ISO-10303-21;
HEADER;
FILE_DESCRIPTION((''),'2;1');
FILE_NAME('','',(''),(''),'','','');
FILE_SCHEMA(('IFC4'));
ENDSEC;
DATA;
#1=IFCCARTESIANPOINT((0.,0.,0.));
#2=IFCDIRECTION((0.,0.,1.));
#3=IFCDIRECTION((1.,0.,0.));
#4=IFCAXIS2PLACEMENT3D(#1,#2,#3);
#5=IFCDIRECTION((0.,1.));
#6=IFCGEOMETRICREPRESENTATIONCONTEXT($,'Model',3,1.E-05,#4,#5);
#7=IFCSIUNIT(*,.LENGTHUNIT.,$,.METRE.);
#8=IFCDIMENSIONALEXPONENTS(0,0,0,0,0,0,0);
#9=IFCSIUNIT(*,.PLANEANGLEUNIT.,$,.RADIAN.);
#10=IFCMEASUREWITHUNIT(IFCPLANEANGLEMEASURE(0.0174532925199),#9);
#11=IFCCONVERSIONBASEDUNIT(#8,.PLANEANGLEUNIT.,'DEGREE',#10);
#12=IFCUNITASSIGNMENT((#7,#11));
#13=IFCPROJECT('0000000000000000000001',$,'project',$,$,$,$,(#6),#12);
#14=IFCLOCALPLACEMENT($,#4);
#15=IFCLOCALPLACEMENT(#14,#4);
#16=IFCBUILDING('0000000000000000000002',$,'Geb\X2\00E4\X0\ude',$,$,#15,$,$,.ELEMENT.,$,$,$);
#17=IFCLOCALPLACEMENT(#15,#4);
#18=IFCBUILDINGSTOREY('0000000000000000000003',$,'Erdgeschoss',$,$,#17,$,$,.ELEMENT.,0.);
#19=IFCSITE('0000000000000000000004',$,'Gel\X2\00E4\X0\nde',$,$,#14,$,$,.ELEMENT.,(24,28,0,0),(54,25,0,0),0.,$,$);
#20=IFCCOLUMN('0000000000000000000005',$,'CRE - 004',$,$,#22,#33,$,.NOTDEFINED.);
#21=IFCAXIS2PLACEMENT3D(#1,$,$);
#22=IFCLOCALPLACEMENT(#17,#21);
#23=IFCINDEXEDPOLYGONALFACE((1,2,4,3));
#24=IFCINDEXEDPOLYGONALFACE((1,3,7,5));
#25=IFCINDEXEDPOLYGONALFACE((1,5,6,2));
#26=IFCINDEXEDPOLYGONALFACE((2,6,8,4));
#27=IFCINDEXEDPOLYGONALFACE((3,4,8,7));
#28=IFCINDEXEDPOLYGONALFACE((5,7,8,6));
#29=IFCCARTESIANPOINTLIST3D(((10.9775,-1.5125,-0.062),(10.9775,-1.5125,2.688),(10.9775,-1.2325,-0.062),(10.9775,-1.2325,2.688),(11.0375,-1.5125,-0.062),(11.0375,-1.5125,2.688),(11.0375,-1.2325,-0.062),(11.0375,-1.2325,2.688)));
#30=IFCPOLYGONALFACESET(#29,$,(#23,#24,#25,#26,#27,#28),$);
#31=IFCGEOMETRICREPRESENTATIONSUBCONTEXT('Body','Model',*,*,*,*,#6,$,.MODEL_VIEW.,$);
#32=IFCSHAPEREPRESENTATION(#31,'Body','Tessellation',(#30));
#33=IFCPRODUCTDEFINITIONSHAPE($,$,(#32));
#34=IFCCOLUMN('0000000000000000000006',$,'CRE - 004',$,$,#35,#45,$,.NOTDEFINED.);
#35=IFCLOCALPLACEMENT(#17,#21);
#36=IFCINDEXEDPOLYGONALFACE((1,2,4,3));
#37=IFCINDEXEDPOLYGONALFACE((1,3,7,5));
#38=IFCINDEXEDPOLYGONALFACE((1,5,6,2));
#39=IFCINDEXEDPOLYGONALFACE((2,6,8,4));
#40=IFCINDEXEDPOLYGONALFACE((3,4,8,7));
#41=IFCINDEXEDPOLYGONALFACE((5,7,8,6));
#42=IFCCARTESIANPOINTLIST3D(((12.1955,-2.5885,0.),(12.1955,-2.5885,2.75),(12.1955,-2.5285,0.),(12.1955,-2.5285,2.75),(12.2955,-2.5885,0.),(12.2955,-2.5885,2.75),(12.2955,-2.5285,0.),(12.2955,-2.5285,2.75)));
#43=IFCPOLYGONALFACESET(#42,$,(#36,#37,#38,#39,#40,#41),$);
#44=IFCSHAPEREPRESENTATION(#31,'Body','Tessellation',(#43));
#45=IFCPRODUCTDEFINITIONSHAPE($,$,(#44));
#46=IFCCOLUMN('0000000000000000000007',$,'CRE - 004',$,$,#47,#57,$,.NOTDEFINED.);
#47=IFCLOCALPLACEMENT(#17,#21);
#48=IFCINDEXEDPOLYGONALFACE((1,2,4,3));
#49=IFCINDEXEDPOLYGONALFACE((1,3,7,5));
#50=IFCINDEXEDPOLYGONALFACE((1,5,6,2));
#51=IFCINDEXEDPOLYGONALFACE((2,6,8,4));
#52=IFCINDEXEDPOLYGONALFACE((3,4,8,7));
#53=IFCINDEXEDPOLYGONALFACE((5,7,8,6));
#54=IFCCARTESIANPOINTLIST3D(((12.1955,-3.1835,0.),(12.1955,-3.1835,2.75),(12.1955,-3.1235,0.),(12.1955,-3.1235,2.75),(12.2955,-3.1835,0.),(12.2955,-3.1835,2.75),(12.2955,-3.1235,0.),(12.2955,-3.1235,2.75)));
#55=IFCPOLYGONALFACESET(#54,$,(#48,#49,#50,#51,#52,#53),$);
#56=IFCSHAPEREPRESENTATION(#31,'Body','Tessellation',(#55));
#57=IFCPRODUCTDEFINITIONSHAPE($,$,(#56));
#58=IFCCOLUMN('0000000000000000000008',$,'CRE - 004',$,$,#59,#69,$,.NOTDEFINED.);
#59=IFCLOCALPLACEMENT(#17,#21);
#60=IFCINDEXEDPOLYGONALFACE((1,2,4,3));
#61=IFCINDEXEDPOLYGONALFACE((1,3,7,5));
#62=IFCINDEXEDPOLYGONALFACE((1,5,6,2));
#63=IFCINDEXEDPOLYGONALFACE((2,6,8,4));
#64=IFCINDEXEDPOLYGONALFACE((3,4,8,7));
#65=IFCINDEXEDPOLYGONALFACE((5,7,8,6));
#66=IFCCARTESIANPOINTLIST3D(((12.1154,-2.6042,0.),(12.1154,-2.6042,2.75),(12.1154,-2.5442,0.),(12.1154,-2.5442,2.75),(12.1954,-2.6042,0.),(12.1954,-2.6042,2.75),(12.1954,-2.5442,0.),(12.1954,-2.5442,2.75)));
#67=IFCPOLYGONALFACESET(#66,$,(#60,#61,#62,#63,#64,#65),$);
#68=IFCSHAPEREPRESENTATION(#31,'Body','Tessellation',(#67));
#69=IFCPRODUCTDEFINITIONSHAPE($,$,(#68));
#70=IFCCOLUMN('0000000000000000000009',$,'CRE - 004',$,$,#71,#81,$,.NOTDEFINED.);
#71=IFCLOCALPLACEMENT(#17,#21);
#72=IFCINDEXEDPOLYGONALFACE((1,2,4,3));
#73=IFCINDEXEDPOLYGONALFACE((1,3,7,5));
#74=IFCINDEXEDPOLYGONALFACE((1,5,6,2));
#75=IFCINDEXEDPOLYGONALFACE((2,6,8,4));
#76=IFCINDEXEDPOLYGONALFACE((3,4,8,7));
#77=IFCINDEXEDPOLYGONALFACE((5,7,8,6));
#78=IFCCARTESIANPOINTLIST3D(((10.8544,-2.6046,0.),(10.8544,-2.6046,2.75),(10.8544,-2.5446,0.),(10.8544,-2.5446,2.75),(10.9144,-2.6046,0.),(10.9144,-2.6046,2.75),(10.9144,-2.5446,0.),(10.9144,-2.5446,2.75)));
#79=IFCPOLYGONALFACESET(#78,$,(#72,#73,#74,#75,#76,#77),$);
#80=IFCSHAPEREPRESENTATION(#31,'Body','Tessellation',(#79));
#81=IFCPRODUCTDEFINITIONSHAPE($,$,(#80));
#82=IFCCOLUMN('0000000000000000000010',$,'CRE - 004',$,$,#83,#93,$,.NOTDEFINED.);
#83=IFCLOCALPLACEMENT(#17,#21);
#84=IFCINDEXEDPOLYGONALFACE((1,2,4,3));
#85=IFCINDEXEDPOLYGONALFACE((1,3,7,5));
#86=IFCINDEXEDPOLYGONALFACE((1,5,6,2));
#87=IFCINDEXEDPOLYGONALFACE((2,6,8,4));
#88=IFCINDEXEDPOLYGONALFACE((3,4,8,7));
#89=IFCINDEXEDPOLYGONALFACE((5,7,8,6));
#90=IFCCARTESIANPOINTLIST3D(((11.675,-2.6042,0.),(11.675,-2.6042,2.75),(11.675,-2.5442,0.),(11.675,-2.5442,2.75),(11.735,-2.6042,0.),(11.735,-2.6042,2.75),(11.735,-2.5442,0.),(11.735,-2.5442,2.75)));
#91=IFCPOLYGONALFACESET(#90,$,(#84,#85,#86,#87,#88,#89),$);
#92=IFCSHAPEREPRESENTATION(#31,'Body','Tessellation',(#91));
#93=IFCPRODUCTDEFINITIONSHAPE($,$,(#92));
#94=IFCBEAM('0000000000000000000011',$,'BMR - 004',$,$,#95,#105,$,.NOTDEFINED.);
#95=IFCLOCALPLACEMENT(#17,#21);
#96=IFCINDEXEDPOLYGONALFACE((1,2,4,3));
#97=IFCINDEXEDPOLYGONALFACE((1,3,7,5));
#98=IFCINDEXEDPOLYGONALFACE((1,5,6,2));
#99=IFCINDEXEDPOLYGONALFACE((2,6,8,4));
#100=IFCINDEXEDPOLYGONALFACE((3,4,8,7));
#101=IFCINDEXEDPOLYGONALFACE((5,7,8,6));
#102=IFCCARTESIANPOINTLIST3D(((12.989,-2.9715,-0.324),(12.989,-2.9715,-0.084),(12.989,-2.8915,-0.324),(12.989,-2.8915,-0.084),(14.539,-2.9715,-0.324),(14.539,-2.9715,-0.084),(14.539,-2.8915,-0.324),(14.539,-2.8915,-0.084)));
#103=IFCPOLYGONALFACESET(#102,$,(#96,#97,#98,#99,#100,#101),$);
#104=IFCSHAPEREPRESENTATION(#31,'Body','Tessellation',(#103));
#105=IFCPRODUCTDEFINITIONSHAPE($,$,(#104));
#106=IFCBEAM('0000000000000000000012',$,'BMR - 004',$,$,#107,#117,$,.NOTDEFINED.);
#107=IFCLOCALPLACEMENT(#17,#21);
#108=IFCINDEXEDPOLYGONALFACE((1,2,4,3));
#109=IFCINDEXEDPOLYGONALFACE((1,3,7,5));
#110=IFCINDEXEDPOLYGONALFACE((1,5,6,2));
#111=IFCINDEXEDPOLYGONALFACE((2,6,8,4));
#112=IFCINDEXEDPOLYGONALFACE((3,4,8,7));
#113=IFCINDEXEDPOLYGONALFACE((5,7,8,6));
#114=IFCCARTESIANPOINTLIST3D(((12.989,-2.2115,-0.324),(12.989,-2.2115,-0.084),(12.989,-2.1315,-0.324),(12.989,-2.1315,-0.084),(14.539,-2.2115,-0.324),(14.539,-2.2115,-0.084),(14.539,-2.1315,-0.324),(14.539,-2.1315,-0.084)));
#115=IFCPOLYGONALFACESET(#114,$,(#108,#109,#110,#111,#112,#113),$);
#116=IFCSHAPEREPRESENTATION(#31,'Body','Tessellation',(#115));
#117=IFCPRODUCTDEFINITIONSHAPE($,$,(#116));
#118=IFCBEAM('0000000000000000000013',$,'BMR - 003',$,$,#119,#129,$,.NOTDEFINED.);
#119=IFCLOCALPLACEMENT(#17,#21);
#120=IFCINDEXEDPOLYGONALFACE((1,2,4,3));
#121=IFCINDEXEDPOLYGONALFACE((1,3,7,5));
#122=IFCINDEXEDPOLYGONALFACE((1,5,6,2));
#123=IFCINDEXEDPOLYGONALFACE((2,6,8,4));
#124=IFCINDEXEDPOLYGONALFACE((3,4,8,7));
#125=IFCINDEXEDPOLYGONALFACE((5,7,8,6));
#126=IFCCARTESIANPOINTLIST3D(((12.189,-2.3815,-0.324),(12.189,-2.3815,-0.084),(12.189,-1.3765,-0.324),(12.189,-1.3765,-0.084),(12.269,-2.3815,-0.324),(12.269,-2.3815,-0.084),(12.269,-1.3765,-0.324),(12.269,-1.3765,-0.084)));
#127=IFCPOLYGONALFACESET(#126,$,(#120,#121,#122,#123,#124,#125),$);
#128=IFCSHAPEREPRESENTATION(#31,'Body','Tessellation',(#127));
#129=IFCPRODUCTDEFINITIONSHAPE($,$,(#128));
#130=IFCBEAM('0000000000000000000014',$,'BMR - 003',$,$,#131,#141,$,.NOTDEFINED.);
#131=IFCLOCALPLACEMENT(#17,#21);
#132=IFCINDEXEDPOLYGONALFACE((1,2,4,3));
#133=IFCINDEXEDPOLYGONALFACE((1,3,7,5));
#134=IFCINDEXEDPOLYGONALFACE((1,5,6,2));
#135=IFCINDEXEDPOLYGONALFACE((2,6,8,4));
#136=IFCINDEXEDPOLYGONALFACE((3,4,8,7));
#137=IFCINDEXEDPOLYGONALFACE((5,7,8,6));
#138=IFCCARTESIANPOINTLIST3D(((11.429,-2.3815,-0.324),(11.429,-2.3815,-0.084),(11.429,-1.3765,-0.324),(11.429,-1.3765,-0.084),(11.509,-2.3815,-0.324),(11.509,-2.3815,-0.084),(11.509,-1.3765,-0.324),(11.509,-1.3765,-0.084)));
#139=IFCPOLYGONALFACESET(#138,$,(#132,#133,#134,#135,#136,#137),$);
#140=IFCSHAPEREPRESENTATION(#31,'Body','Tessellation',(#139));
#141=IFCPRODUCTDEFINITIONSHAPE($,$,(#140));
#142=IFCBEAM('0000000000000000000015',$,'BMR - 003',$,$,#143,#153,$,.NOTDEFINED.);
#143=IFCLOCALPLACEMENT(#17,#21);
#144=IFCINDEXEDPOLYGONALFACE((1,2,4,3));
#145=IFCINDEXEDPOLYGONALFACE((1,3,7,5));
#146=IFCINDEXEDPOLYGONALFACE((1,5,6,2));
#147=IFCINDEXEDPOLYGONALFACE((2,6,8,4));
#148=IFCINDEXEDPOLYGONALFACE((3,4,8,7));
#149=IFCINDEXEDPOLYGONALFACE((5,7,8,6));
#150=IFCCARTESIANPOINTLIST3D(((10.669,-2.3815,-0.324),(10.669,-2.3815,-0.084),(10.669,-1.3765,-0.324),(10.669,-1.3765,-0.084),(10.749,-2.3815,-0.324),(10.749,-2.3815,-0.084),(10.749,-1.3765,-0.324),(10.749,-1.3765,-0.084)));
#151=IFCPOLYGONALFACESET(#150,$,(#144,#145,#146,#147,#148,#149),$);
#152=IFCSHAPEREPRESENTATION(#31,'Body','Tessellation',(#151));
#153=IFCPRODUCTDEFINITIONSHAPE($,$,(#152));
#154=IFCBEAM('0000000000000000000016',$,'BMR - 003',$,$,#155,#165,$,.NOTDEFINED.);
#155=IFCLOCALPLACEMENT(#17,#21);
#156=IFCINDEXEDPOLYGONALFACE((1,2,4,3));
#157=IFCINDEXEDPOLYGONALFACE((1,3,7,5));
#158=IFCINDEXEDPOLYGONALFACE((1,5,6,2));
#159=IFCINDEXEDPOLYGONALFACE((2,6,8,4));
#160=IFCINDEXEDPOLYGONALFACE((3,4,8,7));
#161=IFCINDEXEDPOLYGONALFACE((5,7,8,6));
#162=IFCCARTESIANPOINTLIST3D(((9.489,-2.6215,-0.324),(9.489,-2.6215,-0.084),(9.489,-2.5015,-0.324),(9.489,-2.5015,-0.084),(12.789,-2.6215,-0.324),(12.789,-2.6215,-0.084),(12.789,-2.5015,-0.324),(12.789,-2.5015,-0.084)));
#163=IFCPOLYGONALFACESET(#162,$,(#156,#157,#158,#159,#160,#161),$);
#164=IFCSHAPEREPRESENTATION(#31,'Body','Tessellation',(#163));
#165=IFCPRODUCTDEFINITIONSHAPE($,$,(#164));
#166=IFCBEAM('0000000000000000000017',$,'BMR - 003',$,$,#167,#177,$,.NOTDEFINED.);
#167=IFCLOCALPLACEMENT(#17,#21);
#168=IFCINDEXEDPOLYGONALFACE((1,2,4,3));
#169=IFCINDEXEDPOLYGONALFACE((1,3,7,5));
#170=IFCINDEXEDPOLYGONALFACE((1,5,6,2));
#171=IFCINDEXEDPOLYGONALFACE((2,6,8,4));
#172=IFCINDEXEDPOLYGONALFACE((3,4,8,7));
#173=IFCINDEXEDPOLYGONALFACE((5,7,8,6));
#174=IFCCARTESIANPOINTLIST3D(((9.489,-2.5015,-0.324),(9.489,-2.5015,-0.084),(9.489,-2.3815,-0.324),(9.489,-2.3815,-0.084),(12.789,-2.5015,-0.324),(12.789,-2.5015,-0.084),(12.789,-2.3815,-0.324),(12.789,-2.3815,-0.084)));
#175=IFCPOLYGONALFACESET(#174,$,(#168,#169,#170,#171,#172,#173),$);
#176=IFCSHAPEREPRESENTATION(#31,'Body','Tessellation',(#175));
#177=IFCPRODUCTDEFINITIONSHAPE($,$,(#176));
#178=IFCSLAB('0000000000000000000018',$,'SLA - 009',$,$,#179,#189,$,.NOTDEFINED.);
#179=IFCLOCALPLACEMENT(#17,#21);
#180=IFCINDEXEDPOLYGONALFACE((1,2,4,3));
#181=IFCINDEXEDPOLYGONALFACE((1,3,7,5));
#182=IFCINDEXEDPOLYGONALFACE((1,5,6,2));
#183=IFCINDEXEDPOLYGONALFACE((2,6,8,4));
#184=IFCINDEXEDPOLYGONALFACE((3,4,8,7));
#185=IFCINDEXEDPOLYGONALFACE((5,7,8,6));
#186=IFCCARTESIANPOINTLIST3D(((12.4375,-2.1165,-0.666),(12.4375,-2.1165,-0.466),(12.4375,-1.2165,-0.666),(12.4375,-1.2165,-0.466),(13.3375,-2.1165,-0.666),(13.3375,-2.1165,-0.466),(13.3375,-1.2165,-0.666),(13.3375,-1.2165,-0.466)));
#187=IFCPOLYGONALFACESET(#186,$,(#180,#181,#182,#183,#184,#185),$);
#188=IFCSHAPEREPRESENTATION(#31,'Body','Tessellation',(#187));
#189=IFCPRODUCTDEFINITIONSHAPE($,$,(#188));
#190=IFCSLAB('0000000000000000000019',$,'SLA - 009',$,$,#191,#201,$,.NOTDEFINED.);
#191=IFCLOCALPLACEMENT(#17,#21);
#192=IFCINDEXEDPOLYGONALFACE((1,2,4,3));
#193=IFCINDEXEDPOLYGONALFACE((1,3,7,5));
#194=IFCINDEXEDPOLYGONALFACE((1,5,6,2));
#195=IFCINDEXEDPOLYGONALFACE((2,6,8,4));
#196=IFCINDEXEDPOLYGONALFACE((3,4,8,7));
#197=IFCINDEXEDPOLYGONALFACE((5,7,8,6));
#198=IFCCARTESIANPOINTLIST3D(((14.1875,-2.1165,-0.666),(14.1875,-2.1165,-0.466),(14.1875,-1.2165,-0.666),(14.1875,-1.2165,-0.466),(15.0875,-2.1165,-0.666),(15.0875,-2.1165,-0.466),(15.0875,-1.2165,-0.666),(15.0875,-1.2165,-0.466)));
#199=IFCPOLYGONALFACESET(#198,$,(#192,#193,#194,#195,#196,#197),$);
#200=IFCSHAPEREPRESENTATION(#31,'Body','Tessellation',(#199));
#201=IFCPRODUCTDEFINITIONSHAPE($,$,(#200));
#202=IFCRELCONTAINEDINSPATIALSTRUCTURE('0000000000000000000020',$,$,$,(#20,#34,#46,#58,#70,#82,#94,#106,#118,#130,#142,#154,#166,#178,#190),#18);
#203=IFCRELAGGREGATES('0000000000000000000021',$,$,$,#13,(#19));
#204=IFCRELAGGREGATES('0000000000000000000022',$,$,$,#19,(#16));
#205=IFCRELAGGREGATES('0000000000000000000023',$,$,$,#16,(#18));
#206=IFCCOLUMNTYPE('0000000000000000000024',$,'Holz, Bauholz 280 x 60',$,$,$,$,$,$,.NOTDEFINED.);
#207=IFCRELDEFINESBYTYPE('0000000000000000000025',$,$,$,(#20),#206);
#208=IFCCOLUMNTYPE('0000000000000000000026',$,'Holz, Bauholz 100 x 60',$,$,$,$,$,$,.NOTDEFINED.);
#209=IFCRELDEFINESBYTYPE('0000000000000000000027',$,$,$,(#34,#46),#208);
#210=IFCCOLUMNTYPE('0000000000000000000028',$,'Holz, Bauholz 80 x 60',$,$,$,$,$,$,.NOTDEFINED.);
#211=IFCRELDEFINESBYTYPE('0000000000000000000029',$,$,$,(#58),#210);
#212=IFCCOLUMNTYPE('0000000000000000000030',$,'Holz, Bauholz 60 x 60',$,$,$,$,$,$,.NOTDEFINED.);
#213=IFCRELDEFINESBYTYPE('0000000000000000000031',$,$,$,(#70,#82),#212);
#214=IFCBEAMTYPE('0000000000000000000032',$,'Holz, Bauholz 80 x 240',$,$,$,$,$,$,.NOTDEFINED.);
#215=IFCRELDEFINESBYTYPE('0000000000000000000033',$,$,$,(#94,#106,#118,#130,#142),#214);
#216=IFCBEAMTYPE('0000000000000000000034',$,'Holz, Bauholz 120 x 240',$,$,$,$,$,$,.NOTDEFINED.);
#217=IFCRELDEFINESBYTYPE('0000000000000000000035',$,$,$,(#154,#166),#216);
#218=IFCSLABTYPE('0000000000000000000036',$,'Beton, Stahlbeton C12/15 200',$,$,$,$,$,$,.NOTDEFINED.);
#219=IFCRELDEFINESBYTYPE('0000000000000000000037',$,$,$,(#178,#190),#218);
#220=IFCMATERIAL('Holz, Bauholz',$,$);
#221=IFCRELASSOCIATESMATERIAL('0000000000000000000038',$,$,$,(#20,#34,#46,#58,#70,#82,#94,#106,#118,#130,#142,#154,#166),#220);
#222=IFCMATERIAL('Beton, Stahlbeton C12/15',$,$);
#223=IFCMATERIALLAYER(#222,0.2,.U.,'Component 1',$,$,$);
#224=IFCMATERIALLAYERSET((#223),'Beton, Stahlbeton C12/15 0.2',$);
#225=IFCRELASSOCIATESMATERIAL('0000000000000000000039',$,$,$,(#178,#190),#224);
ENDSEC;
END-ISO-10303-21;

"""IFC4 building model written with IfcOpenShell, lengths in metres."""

from ifc_helpers import new_model, entity, si_unit, converted_unit, direction, frame, frame_2d, origin_with_axes, origin_2d_with_axis, place, context, subcontext, project, spatial, line, indexed_curve, rectangle, outline, extrude, material, layer, layer_set, layer_usage, type_object, element, save


model = new_model("IFC4")

# Units and contexts
model_context = context("Model", 3, precision=1e-05, world=origin_with_axes(), true_north=direction((0.0, 1.0)))
body_context = subcontext(model_context, "Body", "Model", "MODEL_VIEW")
ifc_project = project(units=[si_unit("LENGTHUNIT", "METRE"), converted_unit("PLANEANGLEUNIT", "DEGREE", entity("IfcPlaneAngleMeasure", 0.0174532925199), si_unit("PLANEANGLEUNIT", "RADIAN"), dimensions=[0, 0, 0, 0, 0, 0, 0])], contexts=[model_context])

# Site, building, storey
site_placement = place(None, origin_with_axes())
site = spatial("IfcSite", under=ifc_project, at=site_placement, Name="Gelände", CompositionType="ELEMENT", RefLatitude=(24, 28, 0, 0), RefLongitude=(54, 25, 0, 0), RefElevation=0.0)
building_placement = place(site_placement, origin_with_axes())
building = spatial("IfcBuilding", under=site, at=building_placement, Name="Gebäude", CompositionType="ELEMENT")
storey_placement = place(building_placement, origin_with_axes())
storey = spatial("IfcBuildingStorey", under=building, at=storey_placement, Name="Erdgeschoss", CompositionType="ELEMENT", Elevation=0.0)

# Columns
ifc_material_1 = material(Name="Holz, Bauholz")
column_type_1 = type_object("IfcColumnType", Name="Holz, Bauholz 280 x 60", PredefinedType="NOTDEFINED")
column_1_placement = place(storey_placement, frame((11.0075, -1.3725, -0.062), z_axis=(0.0, 0.0, 1.0), x_axis=(-1.0, 0.0, 0.0)))
element("IfcColumn", 1, at=column_1_placement, inside=storey, type_object=column_type_1, material=ifc_material_1, Name="CRE - 004", PredefinedType="NOTDEFINED", context=body_context, shape_type="SweptSolid", body=[
    extrude(rectangle(XDim=0.28, YDim=0.06, at=origin_2d_with_axis()), frame((0.0, 0.0, 0.0), z_axis=(0.0, 0.0, 1.0), x_axis=(0.0, 1.0, 0.0)), (0.0, 0.0, 1.0), 2.75),
])
column_type_2 = type_object("IfcColumnType", Name="Holz, Bauholz 100 x 60", PredefinedType="NOTDEFINED")
for number, where, z_axis, x_axis, name in (
    (2, (12.2455, -2.5585, 0.0), (0.0, 0.0, 1.0), (0.0, -1.0, 0.0), "CRE - 004"),
    (3, (12.2455, -3.1535, 0.0), (0.0, 0.0, 1.0), (0.0, -1.0, 0.0), "CRE - 004"),
):
    element("IfcColumn", number, at=place(storey_placement, frame(where, z_axis=z_axis, x_axis=x_axis)), inside=storey, type_object=column_type_2, material=ifc_material_1, Name=name, PredefinedType="NOTDEFINED", context=body_context, shape_type="SweptSolid", body=[
        extrude(rectangle(XDim=0.1, YDim=0.06, at=origin_2d_with_axis()), frame((0.0, 0.0, 0.0), z_axis=(0.0, 0.0, 1.0), x_axis=(0.0, 1.0, 0.0)), (0.0, 0.0, 1.0), 2.75),
    ])
column_type_3 = type_object("IfcColumnType", Name="Holz, Bauholz 80 x 60", PredefinedType="NOTDEFINED")
column_2_placement = place(storey_placement, frame((12.1554, -2.5742, 0.0), z_axis=(0.0, 0.0, 1.0), x_axis=(0.0, -1.0, 0.0)))
element("IfcColumn", 4, at=column_2_placement, inside=storey, type_object=column_type_3, material=ifc_material_1, Name="CRE - 004", PredefinedType="NOTDEFINED", context=body_context, shape_type="SweptSolid", body=[
    extrude(rectangle(XDim=0.08, YDim=0.06, at=origin_2d_with_axis()), frame((0.0, 0.0, 0.0), z_axis=(0.0, 0.0, 1.0), x_axis=(0.0, 1.0, 0.0)), (0.0, 0.0, 1.0), 2.75),
])
column_type_4 = type_object("IfcColumnType", Name="Holz, Bauholz 60 x 60", PredefinedType="NOTDEFINED")
for number, where, z_axis, x_axis, name in (
    (5, (10.8844, -2.5746, 0.0), (0.0, 0.0, 1.0), (0.0, -1.0, 0.0), "CRE - 004"),
    (6, (11.705, -2.5742, 0.0), (0.0, 0.0, 1.0), (0.0, -1.0, 0.0), "CRE - 004"),
):
    element("IfcColumn", number, at=place(storey_placement, frame(where, z_axis=z_axis, x_axis=x_axis)), inside=storey, type_object=column_type_4, material=ifc_material_1, Name=name, PredefinedType="NOTDEFINED", context=body_context, shape_type="SweptSolid", body=[
        extrude(rectangle(XDim=0.06, YDim=0.06, at=origin_2d_with_axis()), frame((0.0, 0.0, 0.0), z_axis=(0.0, 0.0, 1.0), x_axis=(0.0, 1.0, 0.0)), (0.0, 0.0, 1.0), 2.75),
    ])

# Beams
beam_type_1 = type_object("IfcBeamType", Name="Holz, Bauholz 80 x 240", PredefinedType="NOTDEFINED")
for number, where, z_axis, x_axis, name in (
    (7, (14.539, -2.9315, -0.084), (0.0, 0.0, 1.0), (0.0, 1.0, 0.0), "BMR - 004"),
    (8, (14.539, -2.1715, -0.084), (0.0, 0.0, 1.0), (0.0, 1.0, 0.0), "BMR - 004"),
):
    element("IfcBeam", number, at=place(storey_placement, frame(where, z_axis=z_axis, x_axis=x_axis)), inside=storey, type_object=beam_type_1, material=ifc_material_1, Name=name, PredefinedType="NOTDEFINED", context=body_context, shape_type="SweptSolid", body=[
        extrude(rectangle(XDim=0.24, YDim=0.08, at=frame_2d((-0.12, 0.0), x_axis=(1.0, 0.0))), frame((0.0, 0.0, 0.0), z_axis=(0.0, 1.0, 0.0), x_axis=(0.0, 0.0, 1.0)), (0.0, 0.0, 1.0), 1.55),
    ])
for number, where, z_axis, x_axis, name in (
    (9, (12.229, -2.3815, -0.084), (0.0, 0.0, 1.0), (1.0, 0.0, 0.0), "BMR - 003"),
    (10, (11.469, -2.3815, -0.084), (0.0, 0.0, 1.0), (1.0, 0.0, 0.0), "BMR - 003"),
    (11, (10.709, -2.3815, -0.084), (0.0, 0.0, 1.0), (1.0, 0.0, 0.0), "BMR - 003"),
):
    element("IfcBeam", number, at=place(storey_placement, frame(where, z_axis=z_axis, x_axis=x_axis)), inside=storey, type_object=beam_type_1, material=ifc_material_1, Name=name, PredefinedType="NOTDEFINED", context=body_context, shape_type="SweptSolid", body=[
        extrude(rectangle(XDim=0.24, YDim=0.08, at=frame_2d((-0.12, 0.0), x_axis=(1.0, 0.0))), frame((0.0, 0.0, 0.0), z_axis=(0.0, 1.0, 0.0), x_axis=(0.0, 0.0, 1.0)), (0.0, 0.0, 1.0), 1.005),
    ])
beam_type_2 = type_object("IfcBeamType", Name="Holz, Bauholz 120 x 240", PredefinedType="NOTDEFINED")
for number, where, z_axis, x_axis, name in (
    (12, (12.789, -2.5615, -0.084), (0.0, 0.0, 1.0), (0.0, 1.0, 0.0), "BMR - 003"),
    (13, (12.789, -2.4415, -0.084), (0.0, 0.0, 1.0), (0.0, 1.0, 0.0), "BMR - 003"),
):
    element("IfcBeam", number, at=place(storey_placement, frame(where, z_axis=z_axis, x_axis=x_axis)), inside=storey, type_object=beam_type_2, material=ifc_material_1, Name=name, PredefinedType="NOTDEFINED", context=body_context, shape_type="SweptSolid", body=[
        extrude(rectangle(XDim=0.24, YDim=0.12, at=frame_2d((-0.12, 0.0), x_axis=(1.0, 0.0))), frame((0.0, 0.0, 0.0), z_axis=(0.0, 1.0, 0.0), x_axis=(0.0, 0.0, 1.0)), (0.0, 0.0, 1.0), 3.3),
    ])

# Slabs
ifc_material_2 = material(Name="Beton, Stahlbeton C12/15")
ifc_layer = layer(ifc_material_2, 0.2, ventilated="UNKNOWN", Name="Component 1")
ifc_layer_set = layer_set([ifc_layer], Name="Beton, Stahlbeton C12/15 0.2")
ifc_layer_usage_1 = layer_usage(ifc_layer_set, "AXIS3", "NEGATIVE", 0.2)
slab_type = type_object("IfcSlabType", Name="Beton, Stahlbeton C12/15 200", PredefinedType="NOTDEFINED")
slab_1_placement = place(storey_placement, frame((12.4375, -2.1165, -0.466), z_axis=(0.0, 0.0, 1.0), x_axis=(1.0, 0.0, 0.0)))
element("IfcSlab", 14, at=slab_1_placement, inside=storey, type_object=slab_type, material=ifc_layer_usage_1, Name="SLA - 009", PredefinedType="NOTDEFINED", context=body_context, shape_type="SweptSolid", body=[
    extrude(outline(indexed_curve([(0.0, 0.0), (0.9, 0.0), (0.9, 0.9), (0.0, 0.9)], segments=[line(1, 2, 3, 4, 1)])), frame((0.0, 0.0, -0.2), z_axis=(0.0, 0.0, 1.0), x_axis=(1.0, 0.0, 0.0)), (0.0, 0.0, 1.0), 0.2),
])
ifc_layer_usage_2 = layer_usage(ifc_layer_set, "AXIS3", "NEGATIVE", 0.2)
slab_2_placement = place(storey_placement, frame((14.1875, -2.1165, -0.466), z_axis=(0.0, 0.0, 1.0), x_axis=(1.0, 0.0, 0.0)))
element("IfcSlab", 15, at=slab_2_placement, inside=storey, type_object=slab_type, material=ifc_layer_usage_2, Name="SLA - 009", PredefinedType="NOTDEFINED", context=body_context, shape_type="SweptSolid", body=[
    extrude(outline(indexed_curve([(0.0, 0.0), (0.9, 0.0), (0.9, 0.9), (0.0, 0.9)], segments=[line(1, 2, 3, 4, 1)])), frame((0.0, 0.0, -0.2), z_axis=(0.0, 0.0, 1.0), x_axis=(1.0, 0.0, 0.0)), (0.0, 0.0, 1.0), 0.2),
])

save(model, "model.ifc")
